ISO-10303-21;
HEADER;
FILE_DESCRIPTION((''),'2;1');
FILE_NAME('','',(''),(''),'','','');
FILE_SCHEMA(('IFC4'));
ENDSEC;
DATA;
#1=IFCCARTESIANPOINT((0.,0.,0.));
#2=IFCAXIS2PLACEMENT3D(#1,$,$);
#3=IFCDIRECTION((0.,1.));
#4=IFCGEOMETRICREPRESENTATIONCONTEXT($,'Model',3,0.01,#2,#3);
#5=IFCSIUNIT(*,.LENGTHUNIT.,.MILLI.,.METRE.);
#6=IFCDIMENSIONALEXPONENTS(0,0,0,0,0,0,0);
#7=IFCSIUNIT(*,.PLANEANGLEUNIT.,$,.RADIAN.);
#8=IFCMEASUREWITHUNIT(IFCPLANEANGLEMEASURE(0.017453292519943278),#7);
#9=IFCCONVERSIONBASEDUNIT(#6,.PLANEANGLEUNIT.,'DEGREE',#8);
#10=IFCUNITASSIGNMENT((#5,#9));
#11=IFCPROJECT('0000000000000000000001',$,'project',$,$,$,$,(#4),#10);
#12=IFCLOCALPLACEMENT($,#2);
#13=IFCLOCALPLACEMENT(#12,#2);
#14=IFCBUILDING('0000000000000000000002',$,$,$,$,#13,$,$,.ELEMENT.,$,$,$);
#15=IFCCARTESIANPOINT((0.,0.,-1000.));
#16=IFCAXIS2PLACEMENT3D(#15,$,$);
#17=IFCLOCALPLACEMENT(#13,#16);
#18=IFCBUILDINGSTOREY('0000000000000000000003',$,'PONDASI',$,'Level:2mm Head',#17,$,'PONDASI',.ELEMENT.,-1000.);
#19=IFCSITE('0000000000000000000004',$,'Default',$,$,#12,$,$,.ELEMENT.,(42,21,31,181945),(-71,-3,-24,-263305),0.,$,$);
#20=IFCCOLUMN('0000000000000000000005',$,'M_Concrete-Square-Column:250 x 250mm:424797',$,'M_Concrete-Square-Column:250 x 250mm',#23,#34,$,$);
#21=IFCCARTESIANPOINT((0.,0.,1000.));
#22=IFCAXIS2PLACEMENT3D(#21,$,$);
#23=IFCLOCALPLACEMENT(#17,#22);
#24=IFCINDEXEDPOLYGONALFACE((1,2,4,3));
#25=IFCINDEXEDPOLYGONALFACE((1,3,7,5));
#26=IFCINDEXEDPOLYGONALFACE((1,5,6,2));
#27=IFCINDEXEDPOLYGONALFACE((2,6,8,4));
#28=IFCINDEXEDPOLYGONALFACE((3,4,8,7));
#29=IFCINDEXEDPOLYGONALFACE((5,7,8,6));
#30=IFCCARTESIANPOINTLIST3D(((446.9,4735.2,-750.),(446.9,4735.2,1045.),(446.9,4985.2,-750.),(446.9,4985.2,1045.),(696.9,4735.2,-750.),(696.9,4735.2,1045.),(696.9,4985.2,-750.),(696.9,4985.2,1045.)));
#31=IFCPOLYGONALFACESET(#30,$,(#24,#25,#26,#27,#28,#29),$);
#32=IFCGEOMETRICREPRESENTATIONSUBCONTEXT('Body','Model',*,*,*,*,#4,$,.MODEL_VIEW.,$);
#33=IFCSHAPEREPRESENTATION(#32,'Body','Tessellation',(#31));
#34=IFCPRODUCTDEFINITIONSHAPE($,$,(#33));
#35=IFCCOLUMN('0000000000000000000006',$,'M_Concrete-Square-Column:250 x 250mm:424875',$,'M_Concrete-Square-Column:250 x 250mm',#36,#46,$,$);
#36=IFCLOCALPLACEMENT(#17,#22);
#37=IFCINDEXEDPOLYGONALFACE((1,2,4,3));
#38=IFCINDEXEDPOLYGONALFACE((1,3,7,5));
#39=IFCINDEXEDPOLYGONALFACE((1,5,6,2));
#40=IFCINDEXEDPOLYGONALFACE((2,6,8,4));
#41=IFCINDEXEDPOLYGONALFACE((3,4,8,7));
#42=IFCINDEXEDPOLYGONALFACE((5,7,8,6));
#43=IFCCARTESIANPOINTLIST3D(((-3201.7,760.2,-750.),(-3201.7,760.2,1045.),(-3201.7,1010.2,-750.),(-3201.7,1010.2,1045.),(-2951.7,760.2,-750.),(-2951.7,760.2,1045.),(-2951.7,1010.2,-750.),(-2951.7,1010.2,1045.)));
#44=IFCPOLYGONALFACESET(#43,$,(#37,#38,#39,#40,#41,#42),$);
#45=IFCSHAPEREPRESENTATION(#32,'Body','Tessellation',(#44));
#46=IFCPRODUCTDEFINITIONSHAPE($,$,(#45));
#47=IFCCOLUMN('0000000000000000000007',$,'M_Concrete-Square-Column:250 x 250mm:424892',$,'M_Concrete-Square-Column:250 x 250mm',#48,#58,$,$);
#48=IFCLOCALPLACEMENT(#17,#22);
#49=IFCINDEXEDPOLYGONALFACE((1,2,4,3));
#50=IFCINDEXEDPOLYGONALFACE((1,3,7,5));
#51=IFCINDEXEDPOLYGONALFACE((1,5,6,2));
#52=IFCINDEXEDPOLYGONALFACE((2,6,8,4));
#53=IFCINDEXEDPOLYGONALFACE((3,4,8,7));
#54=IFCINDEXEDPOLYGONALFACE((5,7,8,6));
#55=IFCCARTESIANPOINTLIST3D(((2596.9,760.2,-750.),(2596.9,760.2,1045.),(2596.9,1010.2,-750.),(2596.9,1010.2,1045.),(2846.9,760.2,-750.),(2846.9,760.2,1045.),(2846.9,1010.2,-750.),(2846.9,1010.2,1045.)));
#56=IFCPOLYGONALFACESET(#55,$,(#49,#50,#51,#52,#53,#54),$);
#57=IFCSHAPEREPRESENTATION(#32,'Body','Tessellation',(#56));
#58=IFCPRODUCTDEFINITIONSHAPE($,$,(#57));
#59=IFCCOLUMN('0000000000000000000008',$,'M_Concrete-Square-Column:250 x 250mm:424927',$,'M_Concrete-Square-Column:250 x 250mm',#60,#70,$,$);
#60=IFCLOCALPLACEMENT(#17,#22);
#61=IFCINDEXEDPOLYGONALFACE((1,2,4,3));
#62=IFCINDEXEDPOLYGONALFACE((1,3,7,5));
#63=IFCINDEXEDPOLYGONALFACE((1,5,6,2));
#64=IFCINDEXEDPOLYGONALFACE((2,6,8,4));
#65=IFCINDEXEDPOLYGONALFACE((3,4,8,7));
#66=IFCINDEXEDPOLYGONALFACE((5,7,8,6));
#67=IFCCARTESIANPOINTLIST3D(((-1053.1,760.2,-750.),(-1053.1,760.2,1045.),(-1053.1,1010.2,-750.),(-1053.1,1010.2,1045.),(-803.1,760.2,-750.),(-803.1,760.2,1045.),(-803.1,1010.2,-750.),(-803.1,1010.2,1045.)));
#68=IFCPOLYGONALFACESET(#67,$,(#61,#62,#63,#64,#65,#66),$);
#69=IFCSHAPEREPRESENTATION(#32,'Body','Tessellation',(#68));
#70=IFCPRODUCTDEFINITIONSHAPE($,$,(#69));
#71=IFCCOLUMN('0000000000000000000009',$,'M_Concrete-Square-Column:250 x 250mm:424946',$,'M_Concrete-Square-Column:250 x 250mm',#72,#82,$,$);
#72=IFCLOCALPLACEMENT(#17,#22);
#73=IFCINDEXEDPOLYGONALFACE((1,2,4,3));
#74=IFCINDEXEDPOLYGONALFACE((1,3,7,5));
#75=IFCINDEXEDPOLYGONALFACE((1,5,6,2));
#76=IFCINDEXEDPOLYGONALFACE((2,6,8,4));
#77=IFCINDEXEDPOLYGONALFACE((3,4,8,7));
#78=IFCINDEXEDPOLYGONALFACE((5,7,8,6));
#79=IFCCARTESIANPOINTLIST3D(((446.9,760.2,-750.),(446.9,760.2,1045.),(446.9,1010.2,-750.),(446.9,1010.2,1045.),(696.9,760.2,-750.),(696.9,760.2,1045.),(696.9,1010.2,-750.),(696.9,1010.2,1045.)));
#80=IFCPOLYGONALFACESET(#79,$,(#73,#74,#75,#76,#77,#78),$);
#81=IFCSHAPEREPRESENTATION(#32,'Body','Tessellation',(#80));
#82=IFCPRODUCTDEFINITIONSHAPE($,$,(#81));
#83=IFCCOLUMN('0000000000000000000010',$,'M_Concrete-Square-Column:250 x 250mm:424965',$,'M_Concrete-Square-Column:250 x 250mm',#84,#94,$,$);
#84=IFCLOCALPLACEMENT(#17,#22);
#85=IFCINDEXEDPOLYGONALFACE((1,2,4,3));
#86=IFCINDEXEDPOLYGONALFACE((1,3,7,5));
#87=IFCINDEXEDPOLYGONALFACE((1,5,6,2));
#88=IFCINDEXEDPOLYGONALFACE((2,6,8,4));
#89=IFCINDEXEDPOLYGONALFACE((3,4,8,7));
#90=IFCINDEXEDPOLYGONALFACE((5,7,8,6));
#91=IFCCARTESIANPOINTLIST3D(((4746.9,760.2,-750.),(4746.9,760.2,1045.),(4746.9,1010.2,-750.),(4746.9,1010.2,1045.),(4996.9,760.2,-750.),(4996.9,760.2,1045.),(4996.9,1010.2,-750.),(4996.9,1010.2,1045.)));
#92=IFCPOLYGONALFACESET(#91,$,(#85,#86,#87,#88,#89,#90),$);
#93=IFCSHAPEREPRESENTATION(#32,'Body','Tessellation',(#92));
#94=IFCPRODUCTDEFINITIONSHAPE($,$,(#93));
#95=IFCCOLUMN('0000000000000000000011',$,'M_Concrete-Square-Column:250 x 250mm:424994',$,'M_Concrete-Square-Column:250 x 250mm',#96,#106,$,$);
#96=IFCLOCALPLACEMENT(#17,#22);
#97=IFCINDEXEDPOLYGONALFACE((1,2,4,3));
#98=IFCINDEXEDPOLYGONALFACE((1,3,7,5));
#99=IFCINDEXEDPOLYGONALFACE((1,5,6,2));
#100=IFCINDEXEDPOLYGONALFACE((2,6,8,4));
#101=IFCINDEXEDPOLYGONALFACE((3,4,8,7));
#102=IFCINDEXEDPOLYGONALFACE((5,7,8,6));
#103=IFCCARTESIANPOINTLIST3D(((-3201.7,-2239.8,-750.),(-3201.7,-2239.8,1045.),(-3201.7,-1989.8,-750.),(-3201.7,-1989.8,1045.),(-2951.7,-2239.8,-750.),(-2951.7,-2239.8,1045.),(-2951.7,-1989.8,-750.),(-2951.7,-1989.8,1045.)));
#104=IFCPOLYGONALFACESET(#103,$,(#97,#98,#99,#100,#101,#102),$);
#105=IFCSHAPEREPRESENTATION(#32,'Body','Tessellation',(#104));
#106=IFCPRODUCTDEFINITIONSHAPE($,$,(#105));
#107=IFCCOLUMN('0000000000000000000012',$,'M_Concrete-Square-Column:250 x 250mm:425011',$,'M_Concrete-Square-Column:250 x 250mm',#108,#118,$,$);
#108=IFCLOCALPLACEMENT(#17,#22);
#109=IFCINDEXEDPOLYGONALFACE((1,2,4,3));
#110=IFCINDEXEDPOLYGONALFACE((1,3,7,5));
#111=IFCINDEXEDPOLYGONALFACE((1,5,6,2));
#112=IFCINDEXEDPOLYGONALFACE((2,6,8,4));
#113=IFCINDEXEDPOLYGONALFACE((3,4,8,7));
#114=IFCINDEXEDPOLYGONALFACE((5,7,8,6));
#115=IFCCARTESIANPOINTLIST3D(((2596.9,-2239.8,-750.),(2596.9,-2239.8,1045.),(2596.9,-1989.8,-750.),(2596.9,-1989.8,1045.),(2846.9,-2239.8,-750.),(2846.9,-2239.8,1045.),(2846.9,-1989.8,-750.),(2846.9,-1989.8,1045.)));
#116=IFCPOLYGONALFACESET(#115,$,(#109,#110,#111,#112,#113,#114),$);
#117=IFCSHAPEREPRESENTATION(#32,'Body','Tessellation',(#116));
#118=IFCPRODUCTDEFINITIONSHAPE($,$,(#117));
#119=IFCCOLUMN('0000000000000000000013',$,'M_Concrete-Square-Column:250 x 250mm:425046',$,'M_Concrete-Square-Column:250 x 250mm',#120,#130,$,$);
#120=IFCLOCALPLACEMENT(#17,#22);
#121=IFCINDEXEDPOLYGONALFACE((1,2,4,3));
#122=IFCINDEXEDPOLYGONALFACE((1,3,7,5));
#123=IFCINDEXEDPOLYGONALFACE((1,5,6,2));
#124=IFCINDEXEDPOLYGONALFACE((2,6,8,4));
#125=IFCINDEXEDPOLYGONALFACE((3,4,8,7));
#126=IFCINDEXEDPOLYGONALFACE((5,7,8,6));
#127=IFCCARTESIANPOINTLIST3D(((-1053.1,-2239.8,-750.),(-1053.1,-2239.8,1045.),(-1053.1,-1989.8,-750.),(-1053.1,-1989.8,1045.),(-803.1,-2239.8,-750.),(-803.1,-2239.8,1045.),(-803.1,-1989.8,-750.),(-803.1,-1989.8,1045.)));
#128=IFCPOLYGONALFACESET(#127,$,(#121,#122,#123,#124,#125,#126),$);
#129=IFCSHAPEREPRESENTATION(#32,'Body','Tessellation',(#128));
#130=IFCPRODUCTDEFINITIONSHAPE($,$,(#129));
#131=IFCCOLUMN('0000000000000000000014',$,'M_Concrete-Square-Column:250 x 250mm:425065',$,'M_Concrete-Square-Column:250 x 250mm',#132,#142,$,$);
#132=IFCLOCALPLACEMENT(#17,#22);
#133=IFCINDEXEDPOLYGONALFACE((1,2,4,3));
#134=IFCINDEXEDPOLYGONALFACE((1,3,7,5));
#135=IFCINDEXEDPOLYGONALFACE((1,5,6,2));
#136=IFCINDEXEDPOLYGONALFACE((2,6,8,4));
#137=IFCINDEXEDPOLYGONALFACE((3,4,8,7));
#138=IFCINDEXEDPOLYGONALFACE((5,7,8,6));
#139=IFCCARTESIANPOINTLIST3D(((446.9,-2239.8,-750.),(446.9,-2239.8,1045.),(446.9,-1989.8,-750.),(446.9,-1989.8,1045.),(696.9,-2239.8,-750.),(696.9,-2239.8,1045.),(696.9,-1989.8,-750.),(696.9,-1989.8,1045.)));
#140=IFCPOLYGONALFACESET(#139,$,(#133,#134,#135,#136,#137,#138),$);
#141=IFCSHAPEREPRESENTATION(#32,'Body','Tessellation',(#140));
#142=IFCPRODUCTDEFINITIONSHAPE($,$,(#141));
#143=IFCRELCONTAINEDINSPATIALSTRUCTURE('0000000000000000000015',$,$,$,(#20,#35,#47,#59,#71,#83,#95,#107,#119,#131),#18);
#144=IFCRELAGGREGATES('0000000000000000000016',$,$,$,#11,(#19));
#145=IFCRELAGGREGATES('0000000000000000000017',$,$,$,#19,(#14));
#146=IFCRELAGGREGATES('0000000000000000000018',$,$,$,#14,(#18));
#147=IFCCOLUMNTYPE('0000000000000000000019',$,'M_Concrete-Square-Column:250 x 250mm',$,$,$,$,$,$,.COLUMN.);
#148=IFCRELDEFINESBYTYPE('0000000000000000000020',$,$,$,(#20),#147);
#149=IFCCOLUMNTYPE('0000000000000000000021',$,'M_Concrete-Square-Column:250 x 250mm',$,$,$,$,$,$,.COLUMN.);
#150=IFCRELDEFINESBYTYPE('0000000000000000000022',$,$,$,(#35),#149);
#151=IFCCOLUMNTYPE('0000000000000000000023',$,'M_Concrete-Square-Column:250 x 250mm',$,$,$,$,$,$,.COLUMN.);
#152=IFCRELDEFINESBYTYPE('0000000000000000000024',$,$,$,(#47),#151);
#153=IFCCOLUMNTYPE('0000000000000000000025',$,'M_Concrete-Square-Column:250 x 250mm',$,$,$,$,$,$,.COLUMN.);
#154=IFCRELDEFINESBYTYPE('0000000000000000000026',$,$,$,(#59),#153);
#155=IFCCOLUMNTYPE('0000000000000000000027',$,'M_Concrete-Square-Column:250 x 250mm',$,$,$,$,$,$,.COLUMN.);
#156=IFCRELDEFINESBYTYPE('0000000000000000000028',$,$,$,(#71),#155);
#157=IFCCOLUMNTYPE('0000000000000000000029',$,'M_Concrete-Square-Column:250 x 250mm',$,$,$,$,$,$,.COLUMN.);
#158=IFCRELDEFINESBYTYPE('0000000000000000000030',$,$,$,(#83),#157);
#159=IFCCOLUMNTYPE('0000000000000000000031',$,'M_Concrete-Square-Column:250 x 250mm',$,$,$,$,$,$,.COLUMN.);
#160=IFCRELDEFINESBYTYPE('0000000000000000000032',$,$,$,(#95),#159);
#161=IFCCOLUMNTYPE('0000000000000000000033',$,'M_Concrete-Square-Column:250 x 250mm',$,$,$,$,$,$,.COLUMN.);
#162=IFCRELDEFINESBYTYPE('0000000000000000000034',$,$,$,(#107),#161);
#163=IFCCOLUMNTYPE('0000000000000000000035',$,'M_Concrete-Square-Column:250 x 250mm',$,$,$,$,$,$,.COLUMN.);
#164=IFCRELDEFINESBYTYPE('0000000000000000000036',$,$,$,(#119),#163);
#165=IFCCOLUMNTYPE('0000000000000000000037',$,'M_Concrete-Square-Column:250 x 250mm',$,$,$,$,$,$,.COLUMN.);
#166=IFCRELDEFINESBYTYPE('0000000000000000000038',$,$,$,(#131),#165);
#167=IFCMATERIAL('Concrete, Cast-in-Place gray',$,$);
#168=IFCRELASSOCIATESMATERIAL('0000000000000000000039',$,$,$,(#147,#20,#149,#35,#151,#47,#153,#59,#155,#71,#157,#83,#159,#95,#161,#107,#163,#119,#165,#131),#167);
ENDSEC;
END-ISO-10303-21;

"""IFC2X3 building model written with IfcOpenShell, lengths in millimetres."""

from ifc_helpers import new_model, entity, si_unit, converted_unit, direction, frame, frame_2d, origin, origin_2d_with_axis, place, context, subcontext, project, spatial, rectangle, extrude, source, transform, mapped, material, type_object, type_shapes, element, save


model = new_model("IFC2X3")

# Units and contexts
model_context = context("Model", 3, precision=0.01, world=origin(), true_north=direction((0.0, 1.0)))
body_context = subcontext(model_context, "Body", "Model", "MODEL_VIEW")
ifc_project = project(units=[si_unit("LENGTHUNIT", "METRE", prefix="MILLI"), converted_unit("PLANEANGLEUNIT", "DEGREE", entity("IfcPlaneAngleMeasure", 0.017453292519943278), si_unit("PLANEANGLEUNIT", "RADIAN"), dimensions=[0, 0, 0, 0, 0, 0, 0])], contexts=[model_context])

# Site, building, storey
site_placement = place(None, origin())
site = spatial("IfcSite", under=ifc_project, at=site_placement, Name="Default", CompositionType="ELEMENT", RefLatitude=(42, 21, 31, 181945), RefLongitude=(-71, -3, -24, -263305), RefElevation=0.0)
building_placement = place(site_placement, origin())
building = spatial("IfcBuilding", under=site, at=building_placement, CompositionType="ELEMENT")
storey_placement = place(building_placement, frame((0.0, 0.0, -1000.0)))
storey = spatial("IfcBuildingStorey", under=building, at=storey_placement, Name="PONDASI", ObjectType="Level:2mm Head", LongName="PONDASI", CompositionType="ELEMENT", Elevation=-1000.0)

# Columns
ifc_material_1 = material(Name="Concrete, Cast-in-Place gray")
column_type_1 = type_object("IfcColumnType", Name="M_Concrete-Square-Column:250 x 250mm", PredefinedType="COLUMN", material=ifc_material_1)
shared_shape_1 = source(origin(), body_context, "Body", "SweptSolid", [
    extrude(rectangle(XDim=250.0, YDim=250.0, at=frame_2d((0.0, 0.0), x_axis=(1.0, 0.0))), frame((571.9, 4860.2, -750.0), z_axis=(0.0, 0.0, 1.0), x_axis=(-1.0, 0.0, 0.0)), (0.0, 0.0, 1.0), 1795.0),
])
type_shapes(column_type_1, [shared_shape_1])
column_1_placement = place(storey_placement, frame((0.0, 0.0, 1000.0)))
element("IfcColumn", 1, at=column_1_placement, inside=storey, type_object=column_type_1, material=ifc_material_1, Name="M_Concrete-Square-Column:250 x 250mm:424797", ObjectType="M_Concrete-Square-Column:250 x 250mm", context=body_context, shape_type="MappedRepresentation", body=[
    mapped(shared_shape_1, transform((0.0, 0.0, 0.0), scale=1.0)),
])
column_type_2 = type_object("IfcColumnType", Name="M_Concrete-Square-Column:250 x 250mm", PredefinedType="COLUMN", material=ifc_material_1)
shared_shape_2 = source(origin(), body_context, "Body", "SweptSolid", [
    extrude(rectangle(XDim=250.0, YDim=250.0, at=frame_2d((0.0, 0.0), x_axis=(1.0, 0.0))), frame((-3076.7, 885.2, -750.0), z_axis=(0.0, 0.0, 1.0), x_axis=(-1.0, 0.0, 0.0)), (0.0, 0.0, 1.0), 1795.0),
])
type_shapes(column_type_2, [shared_shape_2])
column_2_placement = place(storey_placement, frame((0.0, 0.0, 1000.0)))
element("IfcColumn", 2, at=column_2_placement, inside=storey, type_object=column_type_2, material=ifc_material_1, Name="M_Concrete-Square-Column:250 x 250mm:424875", ObjectType="M_Concrete-Square-Column:250 x 250mm", context=body_context, shape_type="MappedRepresentation", body=[
    mapped(shared_shape_2, transform((0.0, 0.0, 0.0), scale=1.0)),
])
column_type_3 = type_object("IfcColumnType", Name="M_Concrete-Square-Column:250 x 250mm", PredefinedType="COLUMN", material=ifc_material_1)
shared_shape_3 = source(origin(), body_context, "Body", "SweptSolid", [
    extrude(rectangle(XDim=250.0, YDim=250.0, at=frame_2d((0.0, 0.0), x_axis=(1.0, 0.0))), frame((2721.9, 885.2, -750.0), z_axis=(0.0, 0.0, 1.0), x_axis=(-1.0, 0.0, 0.0)), (0.0, 0.0, 1.0), 1795.0),
])
type_shapes(column_type_3, [shared_shape_3])
column_3_placement = place(storey_placement, frame((0.0, 0.0, 1000.0)))
element("IfcColumn", 3, at=column_3_placement, inside=storey, type_object=column_type_3, material=ifc_material_1, Name="M_Concrete-Square-Column:250 x 250mm:424892", ObjectType="M_Concrete-Square-Column:250 x 250mm", context=body_context, shape_type="MappedRepresentation", body=[
    mapped(shared_shape_3, transform((0.0, 0.0, 0.0), scale=1.0)),
])
column_type_4 = type_object("IfcColumnType", Name="M_Concrete-Square-Column:250 x 250mm", PredefinedType="COLUMN", material=ifc_material_1)
shared_shape_4 = source(origin(), body_context, "Body", "SweptSolid", [
    extrude(rectangle(XDim=250.0, YDim=250.0, at=origin_2d_with_axis()), frame((-928.1, 885.2, -750.0), z_axis=(0.0, 0.0, 1.0), x_axis=(-1.0, 0.0, 0.0)), (0.0, 0.0, 1.0), 1795.0),
])
type_shapes(column_type_4, [shared_shape_4])
column_4_placement = place(storey_placement, frame((0.0, 0.0, 1000.0)))
element("IfcColumn", 4, at=column_4_placement, inside=storey, type_object=column_type_4, material=ifc_material_1, Name="M_Concrete-Square-Column:250 x 250mm:424927", ObjectType="M_Concrete-Square-Column:250 x 250mm", context=body_context, shape_type="MappedRepresentation", body=[
    mapped(shared_shape_4, transform((0.0, 0.0, 0.0), scale=1.0)),
])
column_type_5 = type_object("IfcColumnType", Name="M_Concrete-Square-Column:250 x 250mm", PredefinedType="COLUMN", material=ifc_material_1)
shared_shape_5 = source(origin(), body_context, "Body", "SweptSolid", [
    extrude(rectangle(XDim=250.0, YDim=250.0, at=origin_2d_with_axis()), frame((571.9, 885.2, -750.0), z_axis=(0.0, 0.0, 1.0), x_axis=(-1.0, 0.0, 0.0)), (0.0, 0.0, 1.0), 1795.0),
])
type_shapes(column_type_5, [shared_shape_5])
column_5_placement = place(storey_placement, frame((0.0, 0.0, 1000.0)))
element("IfcColumn", 5, at=column_5_placement, inside=storey, type_object=column_type_5, material=ifc_material_1, Name="M_Concrete-Square-Column:250 x 250mm:424946", ObjectType="M_Concrete-Square-Column:250 x 250mm", context=body_context, shape_type="MappedRepresentation", body=[
    mapped(shared_shape_5, transform((0.0, 0.0, 0.0), scale=1.0)),
])
column_type_6 = type_object("IfcColumnType", Name="M_Concrete-Square-Column:250 x 250mm", PredefinedType="COLUMN", material=ifc_material_1)
shared_shape_6 = source(origin(), body_context, "Body", "SweptSolid", [
    extrude(rectangle(XDim=250.0, YDim=250.0, at=frame_2d((0.0, 0.0), x_axis=(1.0, 0.0))), frame((4871.9, 885.2, -750.0), z_axis=(0.0, 0.0, 1.0), x_axis=(-1.0, 0.0, 0.0)), (0.0, 0.0, 1.0), 1795.0),
])
type_shapes(column_type_6, [shared_shape_6])
column_6_placement = place(storey_placement, frame((0.0, 0.0, 1000.0)))
element("IfcColumn", 6, at=column_6_placement, inside=storey, type_object=column_type_6, material=ifc_material_1, Name="M_Concrete-Square-Column:250 x 250mm:424965", ObjectType="M_Concrete-Square-Column:250 x 250mm", context=body_context, shape_type="MappedRepresentation", body=[
    mapped(shared_shape_6, transform((0.0, 0.0, 0.0), scale=1.0)),
])
column_type_7 = type_object("IfcColumnType", Name="M_Concrete-Square-Column:250 x 250mm", PredefinedType="COLUMN", material=ifc_material_1)
shared_shape_7 = source(origin(), body_context, "Body", "SweptSolid", [
    extrude(rectangle(XDim=250.0, YDim=250.0, at=frame_2d((0.0, 0.0), x_axis=(1.0, 0.0))), frame((-3076.7, -2114.8, -750.0), z_axis=(0.0, 0.0, 1.0), x_axis=(-1.0, 0.0, 0.0)), (0.0, 0.0, 1.0), 1795.0),
])
type_shapes(column_type_7, [shared_shape_7])
column_7_placement = place(storey_placement, frame((0.0, 0.0, 1000.0)))
element("IfcColumn", 7, at=column_7_placement, inside=storey, type_object=column_type_7, material=ifc_material_1, Name="M_Concrete-Square-Column:250 x 250mm:424994", ObjectType="M_Concrete-Square-Column:250 x 250mm", context=body_context, shape_type="MappedRepresentation", body=[
    mapped(shared_shape_7, transform((0.0, 0.0, 0.0), scale=1.0)),
])
column_type_8 = type_object("IfcColumnType", Name="M_Concrete-Square-Column:250 x 250mm", PredefinedType="COLUMN", material=ifc_material_1)
shared_shape_8 = source(origin(), body_context, "Body", "SweptSolid", [
    extrude(rectangle(XDim=250.0, YDim=250.0, at=frame_2d((0.0, 0.0), x_axis=(1.0, 0.0))), frame((2721.9, -2114.8, -750.0), z_axis=(0.0, 0.0, 1.0), x_axis=(-1.0, 0.0, 0.0)), (0.0, 0.0, 1.0), 1795.0),
])
type_shapes(column_type_8, [shared_shape_8])
column_8_placement = place(storey_placement, frame((0.0, 0.0, 1000.0)))
element("IfcColumn", 8, at=column_8_placement, inside=storey, type_object=column_type_8, material=ifc_material_1, Name="M_Concrete-Square-Column:250 x 250mm:425011", ObjectType="M_Concrete-Square-Column:250 x 250mm", context=body_context, shape_type="MappedRepresentation", body=[
    mapped(shared_shape_8, transform((0.0, 0.0, 0.0), scale=1.0)),
])
column_type_9 = type_object("IfcColumnType", Name="M_Concrete-Square-Column:250 x 250mm", PredefinedType="COLUMN", material=ifc_material_1)
shared_shape_9 = source(origin(), body_context, "Body", "SweptSolid", [
    extrude(rectangle(XDim=250.0, YDim=250.0, at=origin_2d_with_axis()), frame((-928.1, -2114.8, -750.0), z_axis=(0.0, 0.0, 1.0), x_axis=(-1.0, 0.0, 0.0)), (0.0, 0.0, 1.0), 1795.0),
])
type_shapes(column_type_9, [shared_shape_9])
column_9_placement = place(storey_placement, frame((0.0, 0.0, 1000.0)))
element("IfcColumn", 9, at=column_9_placement, inside=storey, type_object=column_type_9, material=ifc_material_1, Name="M_Concrete-Square-Column:250 x 250mm:425046", ObjectType="M_Concrete-Square-Column:250 x 250mm", context=body_context, shape_type="MappedRepresentation", body=[
    mapped(shared_shape_9, transform((0.0, 0.0, 0.0), scale=1.0)),
])
column_type_10 = type_object("IfcColumnType", Name="M_Concrete-Square-Column:250 x 250mm", PredefinedType="COLUMN", material=ifc_material_1)
shared_shape_10 = source(origin(), body_context, "Body", "SweptSolid", [
    extrude(rectangle(XDim=250.0, YDim=250.0, at=origin_2d_with_axis()), frame((571.9, -2114.8, -750.0), z_axis=(0.0, 0.0, 1.0), x_axis=(-1.0, 0.0, 0.0)), (0.0, 0.0, 1.0), 1795.0),
])
type_shapes(column_type_10, [shared_shape_10])
column_10_placement = place(storey_placement, frame((0.0, 0.0, 1000.0)))
element("IfcColumn", 10, at=column_10_placement, inside=storey, type_object=column_type_10, material=ifc_material_1, Name="M_Concrete-Square-Column:250 x 250mm:425065", ObjectType="M_Concrete-Square-Column:250 x 250mm", context=body_context, shape_type="MappedRepresentation", body=[
    mapped(shared_shape_10, transform((0.0, 0.0, 0.0), scale=1.0)),
])

save(model, "model.ifc")
